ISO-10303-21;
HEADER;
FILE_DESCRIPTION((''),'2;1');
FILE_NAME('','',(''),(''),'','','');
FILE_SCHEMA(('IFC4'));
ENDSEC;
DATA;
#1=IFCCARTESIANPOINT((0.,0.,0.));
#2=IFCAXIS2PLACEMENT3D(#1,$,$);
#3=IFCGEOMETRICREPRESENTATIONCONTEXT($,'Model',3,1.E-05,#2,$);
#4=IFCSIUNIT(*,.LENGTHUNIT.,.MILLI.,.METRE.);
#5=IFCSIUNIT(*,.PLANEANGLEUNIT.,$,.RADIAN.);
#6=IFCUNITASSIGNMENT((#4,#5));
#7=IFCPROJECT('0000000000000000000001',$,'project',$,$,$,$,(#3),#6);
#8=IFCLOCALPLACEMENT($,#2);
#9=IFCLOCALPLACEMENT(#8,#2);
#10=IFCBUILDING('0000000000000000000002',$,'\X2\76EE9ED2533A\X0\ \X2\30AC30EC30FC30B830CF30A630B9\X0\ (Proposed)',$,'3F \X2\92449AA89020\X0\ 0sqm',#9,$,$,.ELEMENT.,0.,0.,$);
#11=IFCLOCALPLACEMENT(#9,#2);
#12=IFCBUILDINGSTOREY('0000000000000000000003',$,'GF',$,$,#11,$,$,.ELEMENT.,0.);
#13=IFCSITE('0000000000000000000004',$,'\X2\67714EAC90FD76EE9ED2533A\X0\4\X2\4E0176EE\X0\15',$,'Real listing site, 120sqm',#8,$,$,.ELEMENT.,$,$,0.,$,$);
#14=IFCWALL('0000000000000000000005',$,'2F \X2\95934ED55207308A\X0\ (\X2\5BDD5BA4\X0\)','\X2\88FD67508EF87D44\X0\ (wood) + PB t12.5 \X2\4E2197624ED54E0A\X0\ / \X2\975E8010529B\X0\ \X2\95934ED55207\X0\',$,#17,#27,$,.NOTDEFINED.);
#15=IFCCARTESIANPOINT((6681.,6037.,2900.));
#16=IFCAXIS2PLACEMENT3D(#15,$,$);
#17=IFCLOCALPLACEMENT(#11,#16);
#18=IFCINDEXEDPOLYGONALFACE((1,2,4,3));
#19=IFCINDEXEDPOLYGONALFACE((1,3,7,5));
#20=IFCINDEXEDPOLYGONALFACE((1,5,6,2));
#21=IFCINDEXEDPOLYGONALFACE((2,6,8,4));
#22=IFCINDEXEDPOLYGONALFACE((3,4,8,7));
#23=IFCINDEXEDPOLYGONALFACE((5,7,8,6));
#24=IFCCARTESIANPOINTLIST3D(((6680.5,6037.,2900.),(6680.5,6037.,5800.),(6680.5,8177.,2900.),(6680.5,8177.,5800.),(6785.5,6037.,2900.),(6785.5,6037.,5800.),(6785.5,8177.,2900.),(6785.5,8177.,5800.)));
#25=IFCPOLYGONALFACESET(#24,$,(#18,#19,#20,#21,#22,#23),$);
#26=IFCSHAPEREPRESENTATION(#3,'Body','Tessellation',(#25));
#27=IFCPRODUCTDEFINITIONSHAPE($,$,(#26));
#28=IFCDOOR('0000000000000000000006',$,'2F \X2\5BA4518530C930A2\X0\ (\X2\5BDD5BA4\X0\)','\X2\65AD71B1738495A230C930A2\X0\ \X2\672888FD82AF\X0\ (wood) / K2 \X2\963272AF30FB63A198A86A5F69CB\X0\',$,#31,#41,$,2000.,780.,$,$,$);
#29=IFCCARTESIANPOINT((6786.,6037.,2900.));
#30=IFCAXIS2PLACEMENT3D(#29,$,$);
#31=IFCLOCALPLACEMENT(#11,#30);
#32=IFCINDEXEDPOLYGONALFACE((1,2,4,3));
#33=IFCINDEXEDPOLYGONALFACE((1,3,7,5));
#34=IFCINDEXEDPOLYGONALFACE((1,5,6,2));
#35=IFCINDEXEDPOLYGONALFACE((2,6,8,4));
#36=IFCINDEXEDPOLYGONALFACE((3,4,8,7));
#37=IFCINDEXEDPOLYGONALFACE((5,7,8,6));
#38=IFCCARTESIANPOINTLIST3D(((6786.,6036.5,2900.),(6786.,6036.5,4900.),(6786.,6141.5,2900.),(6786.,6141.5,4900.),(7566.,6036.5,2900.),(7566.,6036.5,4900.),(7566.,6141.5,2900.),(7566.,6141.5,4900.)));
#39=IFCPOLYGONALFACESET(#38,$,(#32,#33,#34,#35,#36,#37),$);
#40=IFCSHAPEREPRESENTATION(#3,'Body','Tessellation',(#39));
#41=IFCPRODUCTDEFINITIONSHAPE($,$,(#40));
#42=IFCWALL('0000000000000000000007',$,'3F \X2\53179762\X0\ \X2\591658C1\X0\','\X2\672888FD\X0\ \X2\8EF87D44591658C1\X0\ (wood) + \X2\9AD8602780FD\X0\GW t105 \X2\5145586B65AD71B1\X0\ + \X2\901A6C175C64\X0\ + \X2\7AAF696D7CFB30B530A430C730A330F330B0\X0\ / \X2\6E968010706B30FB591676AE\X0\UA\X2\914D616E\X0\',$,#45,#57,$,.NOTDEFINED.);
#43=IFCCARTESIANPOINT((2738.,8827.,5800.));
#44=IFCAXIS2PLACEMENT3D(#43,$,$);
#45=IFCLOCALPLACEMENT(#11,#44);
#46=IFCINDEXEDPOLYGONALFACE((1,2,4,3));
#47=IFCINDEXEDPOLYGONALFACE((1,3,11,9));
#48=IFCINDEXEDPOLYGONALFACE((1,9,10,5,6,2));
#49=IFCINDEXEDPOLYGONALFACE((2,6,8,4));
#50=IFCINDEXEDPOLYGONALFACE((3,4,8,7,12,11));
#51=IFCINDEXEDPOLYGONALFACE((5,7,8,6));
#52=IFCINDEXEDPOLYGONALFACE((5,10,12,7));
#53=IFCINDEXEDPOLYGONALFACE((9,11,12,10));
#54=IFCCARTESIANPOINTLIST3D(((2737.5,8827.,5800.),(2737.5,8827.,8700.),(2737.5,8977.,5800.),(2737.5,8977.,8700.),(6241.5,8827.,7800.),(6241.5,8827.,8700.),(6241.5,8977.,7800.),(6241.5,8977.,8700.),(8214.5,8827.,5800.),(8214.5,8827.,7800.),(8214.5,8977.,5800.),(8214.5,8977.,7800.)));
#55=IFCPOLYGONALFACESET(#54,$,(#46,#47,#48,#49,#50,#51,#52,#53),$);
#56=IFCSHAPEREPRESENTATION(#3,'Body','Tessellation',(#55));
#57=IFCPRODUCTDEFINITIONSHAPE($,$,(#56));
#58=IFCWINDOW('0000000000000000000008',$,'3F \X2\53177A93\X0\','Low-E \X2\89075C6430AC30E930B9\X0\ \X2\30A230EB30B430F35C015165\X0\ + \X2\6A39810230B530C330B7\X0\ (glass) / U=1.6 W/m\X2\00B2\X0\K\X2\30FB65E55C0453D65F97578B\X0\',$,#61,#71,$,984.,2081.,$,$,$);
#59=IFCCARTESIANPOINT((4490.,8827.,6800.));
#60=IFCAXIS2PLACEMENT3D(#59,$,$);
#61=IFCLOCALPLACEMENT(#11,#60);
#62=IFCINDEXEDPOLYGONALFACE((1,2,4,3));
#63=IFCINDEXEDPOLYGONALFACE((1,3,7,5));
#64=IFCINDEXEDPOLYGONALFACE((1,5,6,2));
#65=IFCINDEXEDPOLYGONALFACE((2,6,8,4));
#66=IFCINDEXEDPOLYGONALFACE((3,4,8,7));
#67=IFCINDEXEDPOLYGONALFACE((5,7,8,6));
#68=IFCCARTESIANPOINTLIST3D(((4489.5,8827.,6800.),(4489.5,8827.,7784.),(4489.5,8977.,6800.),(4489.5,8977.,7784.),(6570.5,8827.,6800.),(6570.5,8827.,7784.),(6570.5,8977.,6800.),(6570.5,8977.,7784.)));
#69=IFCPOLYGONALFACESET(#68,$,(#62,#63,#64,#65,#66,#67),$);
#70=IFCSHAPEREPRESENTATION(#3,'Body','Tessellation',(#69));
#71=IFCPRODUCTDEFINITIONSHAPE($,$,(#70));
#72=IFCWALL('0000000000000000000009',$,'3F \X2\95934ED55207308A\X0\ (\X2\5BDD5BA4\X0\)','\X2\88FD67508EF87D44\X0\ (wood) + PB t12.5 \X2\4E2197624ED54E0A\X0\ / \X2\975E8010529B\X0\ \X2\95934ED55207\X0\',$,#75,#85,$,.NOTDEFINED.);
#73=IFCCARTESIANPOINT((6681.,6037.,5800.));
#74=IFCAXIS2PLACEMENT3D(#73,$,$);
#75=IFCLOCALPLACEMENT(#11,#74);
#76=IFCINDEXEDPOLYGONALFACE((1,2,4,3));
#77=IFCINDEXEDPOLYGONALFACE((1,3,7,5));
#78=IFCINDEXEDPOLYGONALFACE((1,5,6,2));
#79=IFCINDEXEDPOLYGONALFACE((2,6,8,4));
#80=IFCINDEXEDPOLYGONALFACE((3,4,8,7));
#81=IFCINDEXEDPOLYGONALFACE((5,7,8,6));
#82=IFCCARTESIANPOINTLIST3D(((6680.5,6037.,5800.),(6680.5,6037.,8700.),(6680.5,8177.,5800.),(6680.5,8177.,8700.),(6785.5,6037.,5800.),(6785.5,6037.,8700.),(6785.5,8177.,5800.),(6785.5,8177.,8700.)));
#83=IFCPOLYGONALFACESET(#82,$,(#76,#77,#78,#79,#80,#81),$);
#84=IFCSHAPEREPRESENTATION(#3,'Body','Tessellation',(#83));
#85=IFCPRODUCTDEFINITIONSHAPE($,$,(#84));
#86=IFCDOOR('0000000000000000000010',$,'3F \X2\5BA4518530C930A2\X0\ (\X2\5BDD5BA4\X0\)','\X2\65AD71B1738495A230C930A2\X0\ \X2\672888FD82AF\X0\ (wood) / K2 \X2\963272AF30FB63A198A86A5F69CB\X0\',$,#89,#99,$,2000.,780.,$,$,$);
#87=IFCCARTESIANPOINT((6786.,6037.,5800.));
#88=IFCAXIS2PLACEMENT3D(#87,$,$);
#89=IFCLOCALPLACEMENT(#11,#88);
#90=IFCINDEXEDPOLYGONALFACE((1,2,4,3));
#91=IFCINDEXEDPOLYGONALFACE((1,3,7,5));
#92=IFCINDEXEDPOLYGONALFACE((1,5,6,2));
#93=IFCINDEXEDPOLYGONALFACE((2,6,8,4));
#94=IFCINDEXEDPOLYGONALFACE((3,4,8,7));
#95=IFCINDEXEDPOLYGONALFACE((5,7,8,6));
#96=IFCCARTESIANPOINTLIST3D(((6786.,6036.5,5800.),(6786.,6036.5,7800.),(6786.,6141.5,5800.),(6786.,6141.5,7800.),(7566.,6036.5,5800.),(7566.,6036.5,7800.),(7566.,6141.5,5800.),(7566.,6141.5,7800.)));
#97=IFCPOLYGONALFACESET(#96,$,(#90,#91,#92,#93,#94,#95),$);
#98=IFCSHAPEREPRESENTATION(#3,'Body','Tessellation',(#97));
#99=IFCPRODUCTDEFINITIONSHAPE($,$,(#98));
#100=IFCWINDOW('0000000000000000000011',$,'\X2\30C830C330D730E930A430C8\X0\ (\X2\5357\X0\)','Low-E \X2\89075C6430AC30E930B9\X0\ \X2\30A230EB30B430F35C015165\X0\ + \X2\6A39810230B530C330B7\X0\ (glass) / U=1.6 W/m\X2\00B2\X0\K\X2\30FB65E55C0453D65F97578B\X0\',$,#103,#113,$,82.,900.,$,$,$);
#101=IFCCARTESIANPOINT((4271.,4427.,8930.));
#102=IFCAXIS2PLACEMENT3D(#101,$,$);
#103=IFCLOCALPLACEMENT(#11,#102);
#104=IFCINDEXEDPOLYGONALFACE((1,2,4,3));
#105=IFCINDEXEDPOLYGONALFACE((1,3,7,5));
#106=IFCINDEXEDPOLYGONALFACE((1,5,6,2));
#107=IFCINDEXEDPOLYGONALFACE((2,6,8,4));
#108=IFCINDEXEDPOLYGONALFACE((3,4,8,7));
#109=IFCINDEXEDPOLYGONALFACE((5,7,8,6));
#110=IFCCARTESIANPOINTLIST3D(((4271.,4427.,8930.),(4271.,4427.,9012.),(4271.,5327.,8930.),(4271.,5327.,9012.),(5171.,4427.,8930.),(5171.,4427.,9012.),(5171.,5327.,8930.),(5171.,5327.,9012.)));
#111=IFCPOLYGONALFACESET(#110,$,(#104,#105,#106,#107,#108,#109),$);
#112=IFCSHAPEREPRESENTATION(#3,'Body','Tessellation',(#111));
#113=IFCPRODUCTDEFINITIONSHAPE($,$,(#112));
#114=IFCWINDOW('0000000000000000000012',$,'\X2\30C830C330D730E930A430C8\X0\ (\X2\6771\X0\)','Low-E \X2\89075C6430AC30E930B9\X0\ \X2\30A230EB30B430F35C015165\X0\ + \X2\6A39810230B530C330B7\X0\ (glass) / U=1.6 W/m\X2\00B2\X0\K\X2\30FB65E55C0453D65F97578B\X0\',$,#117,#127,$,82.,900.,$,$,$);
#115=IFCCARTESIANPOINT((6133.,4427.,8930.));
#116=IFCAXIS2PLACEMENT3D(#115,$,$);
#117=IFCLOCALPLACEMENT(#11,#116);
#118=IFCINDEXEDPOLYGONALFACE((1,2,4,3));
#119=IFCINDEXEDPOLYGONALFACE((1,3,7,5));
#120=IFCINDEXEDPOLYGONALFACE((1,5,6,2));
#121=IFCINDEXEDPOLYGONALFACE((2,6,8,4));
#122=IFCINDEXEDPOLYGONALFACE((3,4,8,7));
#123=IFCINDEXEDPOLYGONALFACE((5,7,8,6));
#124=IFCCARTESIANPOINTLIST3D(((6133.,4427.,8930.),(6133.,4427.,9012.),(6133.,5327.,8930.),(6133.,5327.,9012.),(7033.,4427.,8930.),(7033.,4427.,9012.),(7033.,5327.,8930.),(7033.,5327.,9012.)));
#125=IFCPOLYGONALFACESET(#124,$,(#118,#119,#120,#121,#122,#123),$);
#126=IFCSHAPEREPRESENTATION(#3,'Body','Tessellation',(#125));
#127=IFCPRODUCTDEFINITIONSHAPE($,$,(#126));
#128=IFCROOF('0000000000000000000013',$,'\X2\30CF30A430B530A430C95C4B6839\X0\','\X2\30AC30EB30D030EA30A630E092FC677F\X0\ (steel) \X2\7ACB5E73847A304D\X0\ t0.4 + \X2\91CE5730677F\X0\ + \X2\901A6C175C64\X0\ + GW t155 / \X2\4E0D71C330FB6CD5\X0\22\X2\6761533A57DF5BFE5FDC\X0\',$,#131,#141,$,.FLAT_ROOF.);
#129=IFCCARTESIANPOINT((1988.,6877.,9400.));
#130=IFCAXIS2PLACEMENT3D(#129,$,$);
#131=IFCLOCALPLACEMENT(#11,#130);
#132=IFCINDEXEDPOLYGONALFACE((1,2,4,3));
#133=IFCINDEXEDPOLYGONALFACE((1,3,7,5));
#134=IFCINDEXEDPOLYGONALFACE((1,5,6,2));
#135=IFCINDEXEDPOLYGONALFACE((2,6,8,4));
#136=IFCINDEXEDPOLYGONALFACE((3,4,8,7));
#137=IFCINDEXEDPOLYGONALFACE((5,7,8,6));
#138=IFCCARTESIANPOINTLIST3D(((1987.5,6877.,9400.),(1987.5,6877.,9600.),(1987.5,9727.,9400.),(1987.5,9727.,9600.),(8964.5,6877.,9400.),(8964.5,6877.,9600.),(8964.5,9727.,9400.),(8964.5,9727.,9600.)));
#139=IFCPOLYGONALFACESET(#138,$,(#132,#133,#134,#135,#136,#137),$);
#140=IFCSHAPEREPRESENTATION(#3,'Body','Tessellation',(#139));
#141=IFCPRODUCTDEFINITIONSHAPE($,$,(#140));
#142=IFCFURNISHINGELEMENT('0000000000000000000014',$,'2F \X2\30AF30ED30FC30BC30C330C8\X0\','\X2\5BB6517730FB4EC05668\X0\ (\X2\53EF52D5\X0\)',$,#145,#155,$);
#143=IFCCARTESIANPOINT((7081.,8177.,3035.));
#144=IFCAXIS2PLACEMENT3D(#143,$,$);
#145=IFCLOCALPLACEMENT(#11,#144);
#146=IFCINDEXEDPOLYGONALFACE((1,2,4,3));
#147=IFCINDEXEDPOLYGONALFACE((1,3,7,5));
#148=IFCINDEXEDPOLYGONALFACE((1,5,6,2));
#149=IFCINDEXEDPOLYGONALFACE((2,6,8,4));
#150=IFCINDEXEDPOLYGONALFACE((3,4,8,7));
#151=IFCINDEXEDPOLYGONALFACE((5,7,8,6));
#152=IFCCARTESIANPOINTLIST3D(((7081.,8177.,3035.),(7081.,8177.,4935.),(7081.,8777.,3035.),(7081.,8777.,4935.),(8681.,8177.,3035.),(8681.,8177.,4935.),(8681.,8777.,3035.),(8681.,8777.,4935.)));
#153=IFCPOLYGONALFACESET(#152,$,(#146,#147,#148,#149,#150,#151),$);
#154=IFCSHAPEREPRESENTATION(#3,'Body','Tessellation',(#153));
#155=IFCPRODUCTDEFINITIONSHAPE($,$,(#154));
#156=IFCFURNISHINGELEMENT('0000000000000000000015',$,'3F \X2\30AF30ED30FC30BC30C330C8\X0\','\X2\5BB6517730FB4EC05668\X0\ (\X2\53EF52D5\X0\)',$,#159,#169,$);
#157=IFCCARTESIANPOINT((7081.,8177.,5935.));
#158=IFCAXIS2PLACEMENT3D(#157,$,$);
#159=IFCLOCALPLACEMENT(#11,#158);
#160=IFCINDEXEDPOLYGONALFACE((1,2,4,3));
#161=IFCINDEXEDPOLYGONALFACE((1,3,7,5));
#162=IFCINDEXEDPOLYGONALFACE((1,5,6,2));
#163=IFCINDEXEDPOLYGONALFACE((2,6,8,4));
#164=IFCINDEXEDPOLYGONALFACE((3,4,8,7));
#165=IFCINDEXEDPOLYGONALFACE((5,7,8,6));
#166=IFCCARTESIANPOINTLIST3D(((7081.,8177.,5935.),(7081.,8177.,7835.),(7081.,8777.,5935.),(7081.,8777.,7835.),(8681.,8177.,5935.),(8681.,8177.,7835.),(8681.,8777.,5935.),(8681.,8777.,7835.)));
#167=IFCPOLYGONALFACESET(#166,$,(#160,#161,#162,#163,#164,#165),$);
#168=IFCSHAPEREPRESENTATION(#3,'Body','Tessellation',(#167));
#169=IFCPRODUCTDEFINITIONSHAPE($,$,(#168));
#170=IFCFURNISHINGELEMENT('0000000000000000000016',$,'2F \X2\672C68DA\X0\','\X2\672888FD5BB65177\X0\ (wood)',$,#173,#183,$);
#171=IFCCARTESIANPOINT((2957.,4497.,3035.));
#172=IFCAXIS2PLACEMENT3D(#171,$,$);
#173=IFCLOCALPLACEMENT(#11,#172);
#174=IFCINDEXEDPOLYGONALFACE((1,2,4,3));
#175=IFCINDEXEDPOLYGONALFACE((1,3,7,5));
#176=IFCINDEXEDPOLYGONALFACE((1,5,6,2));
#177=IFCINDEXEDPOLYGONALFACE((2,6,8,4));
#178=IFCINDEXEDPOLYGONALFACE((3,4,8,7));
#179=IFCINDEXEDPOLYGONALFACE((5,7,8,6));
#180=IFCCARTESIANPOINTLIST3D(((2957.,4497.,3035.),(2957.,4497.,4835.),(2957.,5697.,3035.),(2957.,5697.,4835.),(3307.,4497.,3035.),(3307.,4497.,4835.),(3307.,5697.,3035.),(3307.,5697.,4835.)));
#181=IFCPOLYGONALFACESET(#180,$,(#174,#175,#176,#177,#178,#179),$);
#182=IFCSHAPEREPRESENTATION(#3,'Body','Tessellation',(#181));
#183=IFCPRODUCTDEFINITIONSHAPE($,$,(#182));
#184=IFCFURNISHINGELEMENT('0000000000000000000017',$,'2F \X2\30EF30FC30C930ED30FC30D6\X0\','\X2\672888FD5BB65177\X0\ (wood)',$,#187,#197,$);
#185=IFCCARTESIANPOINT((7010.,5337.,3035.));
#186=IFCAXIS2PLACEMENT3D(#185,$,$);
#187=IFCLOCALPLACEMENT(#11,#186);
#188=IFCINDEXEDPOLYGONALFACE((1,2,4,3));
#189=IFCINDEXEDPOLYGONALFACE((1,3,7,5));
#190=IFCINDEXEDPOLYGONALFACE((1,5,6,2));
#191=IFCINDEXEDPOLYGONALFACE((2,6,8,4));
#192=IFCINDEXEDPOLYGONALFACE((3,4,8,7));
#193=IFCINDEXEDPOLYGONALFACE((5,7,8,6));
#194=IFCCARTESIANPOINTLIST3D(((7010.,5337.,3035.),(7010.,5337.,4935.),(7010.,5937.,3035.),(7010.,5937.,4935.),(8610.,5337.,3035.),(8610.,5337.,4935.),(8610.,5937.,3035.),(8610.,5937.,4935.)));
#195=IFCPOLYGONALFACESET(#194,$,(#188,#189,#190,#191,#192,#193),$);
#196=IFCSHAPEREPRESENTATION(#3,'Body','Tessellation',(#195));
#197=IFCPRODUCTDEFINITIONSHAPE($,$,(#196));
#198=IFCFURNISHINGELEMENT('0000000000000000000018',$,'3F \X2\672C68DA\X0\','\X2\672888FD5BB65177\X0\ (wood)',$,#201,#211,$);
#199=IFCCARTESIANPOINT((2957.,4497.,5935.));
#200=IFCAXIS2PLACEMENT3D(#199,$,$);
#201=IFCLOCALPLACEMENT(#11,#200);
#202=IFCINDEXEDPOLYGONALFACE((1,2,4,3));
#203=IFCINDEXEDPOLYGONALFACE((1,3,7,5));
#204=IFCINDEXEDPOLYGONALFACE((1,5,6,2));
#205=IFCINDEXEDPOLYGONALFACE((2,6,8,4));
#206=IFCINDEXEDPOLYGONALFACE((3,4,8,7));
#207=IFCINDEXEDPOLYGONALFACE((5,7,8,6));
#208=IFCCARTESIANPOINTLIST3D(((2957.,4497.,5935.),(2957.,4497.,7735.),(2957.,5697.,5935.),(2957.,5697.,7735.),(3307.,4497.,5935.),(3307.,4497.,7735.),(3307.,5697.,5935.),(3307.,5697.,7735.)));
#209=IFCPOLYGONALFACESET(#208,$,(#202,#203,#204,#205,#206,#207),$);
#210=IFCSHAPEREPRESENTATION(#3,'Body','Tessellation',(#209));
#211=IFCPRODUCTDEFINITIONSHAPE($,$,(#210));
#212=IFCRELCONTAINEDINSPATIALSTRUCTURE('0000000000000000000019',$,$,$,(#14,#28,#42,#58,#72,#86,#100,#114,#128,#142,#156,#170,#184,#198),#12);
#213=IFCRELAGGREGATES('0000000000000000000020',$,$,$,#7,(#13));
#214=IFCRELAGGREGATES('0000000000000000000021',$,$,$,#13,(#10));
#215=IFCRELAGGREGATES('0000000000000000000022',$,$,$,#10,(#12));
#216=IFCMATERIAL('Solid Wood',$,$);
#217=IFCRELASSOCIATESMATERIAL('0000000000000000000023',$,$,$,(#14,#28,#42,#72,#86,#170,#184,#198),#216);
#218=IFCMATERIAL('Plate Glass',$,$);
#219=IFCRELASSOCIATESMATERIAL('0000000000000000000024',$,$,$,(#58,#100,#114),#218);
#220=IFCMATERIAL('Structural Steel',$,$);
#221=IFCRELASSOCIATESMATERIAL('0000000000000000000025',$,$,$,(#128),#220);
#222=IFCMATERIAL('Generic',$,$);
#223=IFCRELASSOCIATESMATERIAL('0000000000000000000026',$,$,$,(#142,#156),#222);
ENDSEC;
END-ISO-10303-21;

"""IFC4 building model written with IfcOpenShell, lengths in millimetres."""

from ifc_helpers import new_model, si_unit, frame, frame_2d, origin, place, context, project, spatial, rectangle, extrude, material, element, fill, save


model = new_model("IFC4")

# Units and contexts
model_context = context("Model", 3, precision=1e-05, world=origin())
ifc_project = project(units=[si_unit("LENGTHUNIT", "METRE", prefix="MILLI"), si_unit("PLANEANGLEUNIT", "RADIAN")], contexts=[model_context])

# Site, building, storey
site_placement = place(None, origin())
site = spatial("IfcSite", under=ifc_project, at=site_placement, Name="東京都目黒区4丁目15", ObjectType="Real listing site, 120sqm", CompositionType="ELEMENT", RefElevation=0.0)
building_placement = place(site_placement, origin())
building = spatial("IfcBuilding", under=site, at=building_placement, Name="目黒区 ガレージハウス (Proposed)", ObjectType="3F 鉄骨造 0sqm", CompositionType="ELEMENT", ElevationOfRefHeight=0.0, ElevationOfTerrain=0.0)
storey_placement = place(building_placement, origin())
storey = spatial("IfcBuildingStorey", under=building, at=storey_placement, Name="GF", CompositionType="ELEMENT", Elevation=0.0)

# Wall
ifc_material_1 = material(Name="Solid Wood")
wall_1_placement = place(storey_placement, frame((6681.0, 6037.0, 2900.0)))
element("IfcWall", 1, at=wall_1_placement, inside=storey, material=ifc_material_1, Name="2F 間仕切り (寝室)", Description="製材軸組 (wood) + PB t12.5 両面仕上 / 非耐力 間仕切", PredefinedType="NOTDEFINED", context=model_context, shape_type="SweptSolid", body=[
    extrude(rectangle(XDim=105.0, YDim=2140.0, at=frame_2d((52.0, 1070.0))), frame((6681.0, 6037.0, 2900.0)), (0.0, 0.0, 1.0), 2900.0),
])

# Door
door_1_placement = place(storey_placement, frame((6786.0, 6037.0, 2900.0)))
element("IfcDoor", 2, at=door_1_placement, inside=storey, material=ifc_material_1, Name="2F 室内ドア (寝室)", Description="断熱玄関ドア 木製芯 (wood) / K2 防犯・採風機構", OverallHeight=2000.0, OverallWidth=780.0, context=model_context, shape_type="SweptSolid", body=[
    extrude(rectangle(XDim=780.0, YDim=105.0, at=frame_2d((390.0, 52.0))), frame((6786.0, 6037.0, 2900.0)), (0.0, 0.0, 1.0), 2000.0),
])

# Wall, opening, window
wall_2_placement = place(storey_placement, frame((2738.0, 8827.0, 5800.0)))
wall_2 = element("IfcWall", 3, at=wall_2_placement, inside=storey, material=ifc_material_1, Name="3F 北面 外壁", Description="木製 軸組外壁 (wood) + 高性能GW t105 充填断熱 + 通気層 + 窯業系サイディング / 準耐火・外皮UA配慮", PredefinedType="NOTDEFINED", context=model_context, shape_type="SweptSolid", body=[
    extrude(rectangle(XDim=5477.0, YDim=150.0, at=frame_2d((2738.0, 75.0))), frame((2738.0, 8827.0, 5800.0)), (0.0, 0.0, 1.0), 2900.0),
])
opening_1_placement = place(storey_placement, frame((4490.0, 8827.0, 6800.0)))
opening_1 = element("IfcOpeningElement", 4, at=opening_1_placement, cuts=wall_2, PredefinedType="NOTDEFINED", context=model_context, shape_type="SweptSolid", body=[
    extrude(rectangle(XDim=2081.0, YDim=150.0, at=frame_2d((1040.0, 75.0))), frame((4490.0, 8827.0, 6800.0)), (0.0, 0.0, 1.0), 984.0),
])
ifc_material_2 = material(Name="Plate Glass")
window_1_placement = place(storey_placement, frame((4490.0, 8827.0, 6800.0)))
window_1 = element("IfcWindow", 5, at=window_1_placement, inside=storey, material=ifc_material_2, Name="3F 北窓", Description="Low-E 複層ガラス アルゴン封入 + 樹脂サッシ (glass) / U=1.6 W/m²K・日射取得型", OverallHeight=984.0, OverallWidth=2081.0, context=model_context, shape_type="SweptSolid", body=[
    extrude(rectangle(XDim=2081.0, YDim=150.0, at=frame_2d((1040.0, 75.0))), frame((4490.0, 8827.0, 6800.0)), (0.0, 0.0, 1.0), 984.0),
])
fill(opening_1, window_1)

# Wall
wall_3_placement = place(storey_placement, frame((6681.0, 6037.0, 5800.0)))
element("IfcWall", 6, at=wall_3_placement, inside=storey, material=ifc_material_1, Name="3F 間仕切り (寝室)", Description="製材軸組 (wood) + PB t12.5 両面仕上 / 非耐力 間仕切", PredefinedType="NOTDEFINED", context=model_context, shape_type="SweptSolid", body=[
    extrude(rectangle(XDim=105.0, YDim=2140.0, at=frame_2d((52.0, 1070.0))), frame((6681.0, 6037.0, 5800.0)), (0.0, 0.0, 1.0), 2900.0),
])

# Door
door_2_placement = place(storey_placement, frame((6786.0, 6037.0, 5800.0)))
element("IfcDoor", 7, at=door_2_placement, inside=storey, material=ifc_material_1, Name="3F 室内ドア (寝室)", Description="断熱玄関ドア 木製芯 (wood) / K2 防犯・採風機構", OverallHeight=2000.0, OverallWidth=780.0, context=model_context, shape_type="SweptSolid", body=[
    extrude(rectangle(XDim=780.0, YDim=105.0, at=frame_2d((390.0, 52.0))), frame((6786.0, 6037.0, 5800.0)), (0.0, 0.0, 1.0), 2000.0),
])

# Windows
window_2_placement = place(storey_placement, frame((4271.0, 4427.0, 8930.0)))
element("IfcWindow", 8, at=window_2_placement, inside=storey, material=ifc_material_2, Name="トップライト (南)", Description="Low-E 複層ガラス アルゴン封入 + 樹脂サッシ (glass) / U=1.6 W/m²K・日射取得型", OverallHeight=82.0, OverallWidth=900.0, context=model_context, shape_type="SweptSolid", body=[
    extrude(rectangle(XDim=900.0, YDim=900.0, at=frame_2d((450.0, 450.0))), frame((4271.0, 4427.0, 8930.0)), (0.0, 0.0, 1.0), 82.0),
])
window_3_placement = place(storey_placement, frame((6133.0, 4427.0, 8930.0)))
element("IfcWindow", 9, at=window_3_placement, inside=storey, material=ifc_material_2, Name="トップライト (東)", Description="Low-E 複層ガラス アルゴン封入 + 樹脂サッシ (glass) / U=1.6 W/m²K・日射取得型", OverallHeight=82.0, OverallWidth=900.0, context=model_context, shape_type="SweptSolid", body=[
    extrude(rectangle(XDim=900.0, YDim=900.0, at=frame_2d((450.0, 450.0))), frame((6133.0, 4427.0, 8930.0)), (0.0, 0.0, 1.0), 82.0),
])

# Roof
ifc_material_3 = material(Name="Structural Steel")
roof_placement = place(storey_placement, frame((1988.0, 6877.0, 9400.0)))
element("IfcRoof", 10, at=roof_placement, inside=storey, material=ifc_material_3, Name="ハイサイド屋根", Description="ガルバリウム鋼板 (steel) 立平葺き t0.4 + 野地板 + 通気層 + GW t155 / 不燃・法22条区域対応", PredefinedType="FLAT_ROOF", context=model_context, shape_type="SweptSolid", body=[
    extrude(rectangle(XDim=6977.0, YDim=2850.0, at=frame_2d((3488.0, 1425.0))), frame((1988.0, 6877.0, 9400.0)), (0.0, 0.0, 1.0), 200.0),
])

# Furnishing elements
ifc_material_4 = material(Name="Generic")
furnishing_1_placement = place(storey_placement, frame((7081.0, 8177.0, 3035.0)))
element("IfcFurnishingElement", 11, at=furnishing_1_placement, inside=storey, material=ifc_material_4, Name="2F クローゼット", Description="家具・什器 (可動)", context=model_context, shape_type="SweptSolid", body=[
    extrude(rectangle(XDim=1600.0, YDim=600.0, at=frame_2d((800.0, 300.0))), frame((7081.0, 8177.0, 3035.0)), (0.0, 0.0, 1.0), 1900.0),
])
furnishing_2_placement = place(storey_placement, frame((7081.0, 8177.0, 5935.0)))
element("IfcFurnishingElement", 12, at=furnishing_2_placement, inside=storey, material=ifc_material_4, Name="3F クローゼット", Description="家具・什器 (可動)", context=model_context, shape_type="SweptSolid", body=[
    extrude(rectangle(XDim=1600.0, YDim=600.0, at=frame_2d((800.0, 300.0))), frame((7081.0, 8177.0, 5935.0)), (0.0, 0.0, 1.0), 1900.0),
])
furnishing_3_placement = place(storey_placement, frame((2957.0, 4497.0, 3035.0)))
element("IfcFurnishingElement", 13, at=furnishing_3_placement, inside=storey, material=ifc_material_1, Name="2F 本棚", Description="木製家具 (wood)", context=model_context, shape_type="SweptSolid", body=[
    extrude(rectangle(XDim=350.0, YDim=1200.0, at=frame_2d((175.0, 600.0))), frame((2957.0, 4497.0, 3035.0)), (0.0, 0.0, 1.0), 1800.0),
])
furnishing_4_placement = place(storey_placement, frame((7010.0, 5337.0, 3035.0)))
element("IfcFurnishingElement", 14, at=furnishing_4_placement, inside=storey, material=ifc_material_1, Name="2F ワードローブ", Description="木製家具 (wood)", context=model_context, shape_type="SweptSolid", body=[
    extrude(rectangle(XDim=1600.0, YDim=600.0, at=frame_2d((800.0, 300.0))), frame((7010.0, 5337.0, 3035.0)), (0.0, 0.0, 1.0), 1900.0),
])
furnishing_5_placement = place(storey_placement, frame((2957.0, 4497.0, 5935.0)))
element("IfcFurnishingElement", 15, at=furnishing_5_placement, inside=storey, material=ifc_material_1, Name="3F 本棚", Description="木製家具 (wood)", context=model_context, shape_type="SweptSolid", body=[
    extrude(rectangle(XDim=350.0, YDim=1200.0, at=frame_2d((175.0, 600.0))), frame((2957.0, 4497.0, 5935.0)), (0.0, 0.0, 1.0), 1800.0),
])

save(model, "model.ifc")
